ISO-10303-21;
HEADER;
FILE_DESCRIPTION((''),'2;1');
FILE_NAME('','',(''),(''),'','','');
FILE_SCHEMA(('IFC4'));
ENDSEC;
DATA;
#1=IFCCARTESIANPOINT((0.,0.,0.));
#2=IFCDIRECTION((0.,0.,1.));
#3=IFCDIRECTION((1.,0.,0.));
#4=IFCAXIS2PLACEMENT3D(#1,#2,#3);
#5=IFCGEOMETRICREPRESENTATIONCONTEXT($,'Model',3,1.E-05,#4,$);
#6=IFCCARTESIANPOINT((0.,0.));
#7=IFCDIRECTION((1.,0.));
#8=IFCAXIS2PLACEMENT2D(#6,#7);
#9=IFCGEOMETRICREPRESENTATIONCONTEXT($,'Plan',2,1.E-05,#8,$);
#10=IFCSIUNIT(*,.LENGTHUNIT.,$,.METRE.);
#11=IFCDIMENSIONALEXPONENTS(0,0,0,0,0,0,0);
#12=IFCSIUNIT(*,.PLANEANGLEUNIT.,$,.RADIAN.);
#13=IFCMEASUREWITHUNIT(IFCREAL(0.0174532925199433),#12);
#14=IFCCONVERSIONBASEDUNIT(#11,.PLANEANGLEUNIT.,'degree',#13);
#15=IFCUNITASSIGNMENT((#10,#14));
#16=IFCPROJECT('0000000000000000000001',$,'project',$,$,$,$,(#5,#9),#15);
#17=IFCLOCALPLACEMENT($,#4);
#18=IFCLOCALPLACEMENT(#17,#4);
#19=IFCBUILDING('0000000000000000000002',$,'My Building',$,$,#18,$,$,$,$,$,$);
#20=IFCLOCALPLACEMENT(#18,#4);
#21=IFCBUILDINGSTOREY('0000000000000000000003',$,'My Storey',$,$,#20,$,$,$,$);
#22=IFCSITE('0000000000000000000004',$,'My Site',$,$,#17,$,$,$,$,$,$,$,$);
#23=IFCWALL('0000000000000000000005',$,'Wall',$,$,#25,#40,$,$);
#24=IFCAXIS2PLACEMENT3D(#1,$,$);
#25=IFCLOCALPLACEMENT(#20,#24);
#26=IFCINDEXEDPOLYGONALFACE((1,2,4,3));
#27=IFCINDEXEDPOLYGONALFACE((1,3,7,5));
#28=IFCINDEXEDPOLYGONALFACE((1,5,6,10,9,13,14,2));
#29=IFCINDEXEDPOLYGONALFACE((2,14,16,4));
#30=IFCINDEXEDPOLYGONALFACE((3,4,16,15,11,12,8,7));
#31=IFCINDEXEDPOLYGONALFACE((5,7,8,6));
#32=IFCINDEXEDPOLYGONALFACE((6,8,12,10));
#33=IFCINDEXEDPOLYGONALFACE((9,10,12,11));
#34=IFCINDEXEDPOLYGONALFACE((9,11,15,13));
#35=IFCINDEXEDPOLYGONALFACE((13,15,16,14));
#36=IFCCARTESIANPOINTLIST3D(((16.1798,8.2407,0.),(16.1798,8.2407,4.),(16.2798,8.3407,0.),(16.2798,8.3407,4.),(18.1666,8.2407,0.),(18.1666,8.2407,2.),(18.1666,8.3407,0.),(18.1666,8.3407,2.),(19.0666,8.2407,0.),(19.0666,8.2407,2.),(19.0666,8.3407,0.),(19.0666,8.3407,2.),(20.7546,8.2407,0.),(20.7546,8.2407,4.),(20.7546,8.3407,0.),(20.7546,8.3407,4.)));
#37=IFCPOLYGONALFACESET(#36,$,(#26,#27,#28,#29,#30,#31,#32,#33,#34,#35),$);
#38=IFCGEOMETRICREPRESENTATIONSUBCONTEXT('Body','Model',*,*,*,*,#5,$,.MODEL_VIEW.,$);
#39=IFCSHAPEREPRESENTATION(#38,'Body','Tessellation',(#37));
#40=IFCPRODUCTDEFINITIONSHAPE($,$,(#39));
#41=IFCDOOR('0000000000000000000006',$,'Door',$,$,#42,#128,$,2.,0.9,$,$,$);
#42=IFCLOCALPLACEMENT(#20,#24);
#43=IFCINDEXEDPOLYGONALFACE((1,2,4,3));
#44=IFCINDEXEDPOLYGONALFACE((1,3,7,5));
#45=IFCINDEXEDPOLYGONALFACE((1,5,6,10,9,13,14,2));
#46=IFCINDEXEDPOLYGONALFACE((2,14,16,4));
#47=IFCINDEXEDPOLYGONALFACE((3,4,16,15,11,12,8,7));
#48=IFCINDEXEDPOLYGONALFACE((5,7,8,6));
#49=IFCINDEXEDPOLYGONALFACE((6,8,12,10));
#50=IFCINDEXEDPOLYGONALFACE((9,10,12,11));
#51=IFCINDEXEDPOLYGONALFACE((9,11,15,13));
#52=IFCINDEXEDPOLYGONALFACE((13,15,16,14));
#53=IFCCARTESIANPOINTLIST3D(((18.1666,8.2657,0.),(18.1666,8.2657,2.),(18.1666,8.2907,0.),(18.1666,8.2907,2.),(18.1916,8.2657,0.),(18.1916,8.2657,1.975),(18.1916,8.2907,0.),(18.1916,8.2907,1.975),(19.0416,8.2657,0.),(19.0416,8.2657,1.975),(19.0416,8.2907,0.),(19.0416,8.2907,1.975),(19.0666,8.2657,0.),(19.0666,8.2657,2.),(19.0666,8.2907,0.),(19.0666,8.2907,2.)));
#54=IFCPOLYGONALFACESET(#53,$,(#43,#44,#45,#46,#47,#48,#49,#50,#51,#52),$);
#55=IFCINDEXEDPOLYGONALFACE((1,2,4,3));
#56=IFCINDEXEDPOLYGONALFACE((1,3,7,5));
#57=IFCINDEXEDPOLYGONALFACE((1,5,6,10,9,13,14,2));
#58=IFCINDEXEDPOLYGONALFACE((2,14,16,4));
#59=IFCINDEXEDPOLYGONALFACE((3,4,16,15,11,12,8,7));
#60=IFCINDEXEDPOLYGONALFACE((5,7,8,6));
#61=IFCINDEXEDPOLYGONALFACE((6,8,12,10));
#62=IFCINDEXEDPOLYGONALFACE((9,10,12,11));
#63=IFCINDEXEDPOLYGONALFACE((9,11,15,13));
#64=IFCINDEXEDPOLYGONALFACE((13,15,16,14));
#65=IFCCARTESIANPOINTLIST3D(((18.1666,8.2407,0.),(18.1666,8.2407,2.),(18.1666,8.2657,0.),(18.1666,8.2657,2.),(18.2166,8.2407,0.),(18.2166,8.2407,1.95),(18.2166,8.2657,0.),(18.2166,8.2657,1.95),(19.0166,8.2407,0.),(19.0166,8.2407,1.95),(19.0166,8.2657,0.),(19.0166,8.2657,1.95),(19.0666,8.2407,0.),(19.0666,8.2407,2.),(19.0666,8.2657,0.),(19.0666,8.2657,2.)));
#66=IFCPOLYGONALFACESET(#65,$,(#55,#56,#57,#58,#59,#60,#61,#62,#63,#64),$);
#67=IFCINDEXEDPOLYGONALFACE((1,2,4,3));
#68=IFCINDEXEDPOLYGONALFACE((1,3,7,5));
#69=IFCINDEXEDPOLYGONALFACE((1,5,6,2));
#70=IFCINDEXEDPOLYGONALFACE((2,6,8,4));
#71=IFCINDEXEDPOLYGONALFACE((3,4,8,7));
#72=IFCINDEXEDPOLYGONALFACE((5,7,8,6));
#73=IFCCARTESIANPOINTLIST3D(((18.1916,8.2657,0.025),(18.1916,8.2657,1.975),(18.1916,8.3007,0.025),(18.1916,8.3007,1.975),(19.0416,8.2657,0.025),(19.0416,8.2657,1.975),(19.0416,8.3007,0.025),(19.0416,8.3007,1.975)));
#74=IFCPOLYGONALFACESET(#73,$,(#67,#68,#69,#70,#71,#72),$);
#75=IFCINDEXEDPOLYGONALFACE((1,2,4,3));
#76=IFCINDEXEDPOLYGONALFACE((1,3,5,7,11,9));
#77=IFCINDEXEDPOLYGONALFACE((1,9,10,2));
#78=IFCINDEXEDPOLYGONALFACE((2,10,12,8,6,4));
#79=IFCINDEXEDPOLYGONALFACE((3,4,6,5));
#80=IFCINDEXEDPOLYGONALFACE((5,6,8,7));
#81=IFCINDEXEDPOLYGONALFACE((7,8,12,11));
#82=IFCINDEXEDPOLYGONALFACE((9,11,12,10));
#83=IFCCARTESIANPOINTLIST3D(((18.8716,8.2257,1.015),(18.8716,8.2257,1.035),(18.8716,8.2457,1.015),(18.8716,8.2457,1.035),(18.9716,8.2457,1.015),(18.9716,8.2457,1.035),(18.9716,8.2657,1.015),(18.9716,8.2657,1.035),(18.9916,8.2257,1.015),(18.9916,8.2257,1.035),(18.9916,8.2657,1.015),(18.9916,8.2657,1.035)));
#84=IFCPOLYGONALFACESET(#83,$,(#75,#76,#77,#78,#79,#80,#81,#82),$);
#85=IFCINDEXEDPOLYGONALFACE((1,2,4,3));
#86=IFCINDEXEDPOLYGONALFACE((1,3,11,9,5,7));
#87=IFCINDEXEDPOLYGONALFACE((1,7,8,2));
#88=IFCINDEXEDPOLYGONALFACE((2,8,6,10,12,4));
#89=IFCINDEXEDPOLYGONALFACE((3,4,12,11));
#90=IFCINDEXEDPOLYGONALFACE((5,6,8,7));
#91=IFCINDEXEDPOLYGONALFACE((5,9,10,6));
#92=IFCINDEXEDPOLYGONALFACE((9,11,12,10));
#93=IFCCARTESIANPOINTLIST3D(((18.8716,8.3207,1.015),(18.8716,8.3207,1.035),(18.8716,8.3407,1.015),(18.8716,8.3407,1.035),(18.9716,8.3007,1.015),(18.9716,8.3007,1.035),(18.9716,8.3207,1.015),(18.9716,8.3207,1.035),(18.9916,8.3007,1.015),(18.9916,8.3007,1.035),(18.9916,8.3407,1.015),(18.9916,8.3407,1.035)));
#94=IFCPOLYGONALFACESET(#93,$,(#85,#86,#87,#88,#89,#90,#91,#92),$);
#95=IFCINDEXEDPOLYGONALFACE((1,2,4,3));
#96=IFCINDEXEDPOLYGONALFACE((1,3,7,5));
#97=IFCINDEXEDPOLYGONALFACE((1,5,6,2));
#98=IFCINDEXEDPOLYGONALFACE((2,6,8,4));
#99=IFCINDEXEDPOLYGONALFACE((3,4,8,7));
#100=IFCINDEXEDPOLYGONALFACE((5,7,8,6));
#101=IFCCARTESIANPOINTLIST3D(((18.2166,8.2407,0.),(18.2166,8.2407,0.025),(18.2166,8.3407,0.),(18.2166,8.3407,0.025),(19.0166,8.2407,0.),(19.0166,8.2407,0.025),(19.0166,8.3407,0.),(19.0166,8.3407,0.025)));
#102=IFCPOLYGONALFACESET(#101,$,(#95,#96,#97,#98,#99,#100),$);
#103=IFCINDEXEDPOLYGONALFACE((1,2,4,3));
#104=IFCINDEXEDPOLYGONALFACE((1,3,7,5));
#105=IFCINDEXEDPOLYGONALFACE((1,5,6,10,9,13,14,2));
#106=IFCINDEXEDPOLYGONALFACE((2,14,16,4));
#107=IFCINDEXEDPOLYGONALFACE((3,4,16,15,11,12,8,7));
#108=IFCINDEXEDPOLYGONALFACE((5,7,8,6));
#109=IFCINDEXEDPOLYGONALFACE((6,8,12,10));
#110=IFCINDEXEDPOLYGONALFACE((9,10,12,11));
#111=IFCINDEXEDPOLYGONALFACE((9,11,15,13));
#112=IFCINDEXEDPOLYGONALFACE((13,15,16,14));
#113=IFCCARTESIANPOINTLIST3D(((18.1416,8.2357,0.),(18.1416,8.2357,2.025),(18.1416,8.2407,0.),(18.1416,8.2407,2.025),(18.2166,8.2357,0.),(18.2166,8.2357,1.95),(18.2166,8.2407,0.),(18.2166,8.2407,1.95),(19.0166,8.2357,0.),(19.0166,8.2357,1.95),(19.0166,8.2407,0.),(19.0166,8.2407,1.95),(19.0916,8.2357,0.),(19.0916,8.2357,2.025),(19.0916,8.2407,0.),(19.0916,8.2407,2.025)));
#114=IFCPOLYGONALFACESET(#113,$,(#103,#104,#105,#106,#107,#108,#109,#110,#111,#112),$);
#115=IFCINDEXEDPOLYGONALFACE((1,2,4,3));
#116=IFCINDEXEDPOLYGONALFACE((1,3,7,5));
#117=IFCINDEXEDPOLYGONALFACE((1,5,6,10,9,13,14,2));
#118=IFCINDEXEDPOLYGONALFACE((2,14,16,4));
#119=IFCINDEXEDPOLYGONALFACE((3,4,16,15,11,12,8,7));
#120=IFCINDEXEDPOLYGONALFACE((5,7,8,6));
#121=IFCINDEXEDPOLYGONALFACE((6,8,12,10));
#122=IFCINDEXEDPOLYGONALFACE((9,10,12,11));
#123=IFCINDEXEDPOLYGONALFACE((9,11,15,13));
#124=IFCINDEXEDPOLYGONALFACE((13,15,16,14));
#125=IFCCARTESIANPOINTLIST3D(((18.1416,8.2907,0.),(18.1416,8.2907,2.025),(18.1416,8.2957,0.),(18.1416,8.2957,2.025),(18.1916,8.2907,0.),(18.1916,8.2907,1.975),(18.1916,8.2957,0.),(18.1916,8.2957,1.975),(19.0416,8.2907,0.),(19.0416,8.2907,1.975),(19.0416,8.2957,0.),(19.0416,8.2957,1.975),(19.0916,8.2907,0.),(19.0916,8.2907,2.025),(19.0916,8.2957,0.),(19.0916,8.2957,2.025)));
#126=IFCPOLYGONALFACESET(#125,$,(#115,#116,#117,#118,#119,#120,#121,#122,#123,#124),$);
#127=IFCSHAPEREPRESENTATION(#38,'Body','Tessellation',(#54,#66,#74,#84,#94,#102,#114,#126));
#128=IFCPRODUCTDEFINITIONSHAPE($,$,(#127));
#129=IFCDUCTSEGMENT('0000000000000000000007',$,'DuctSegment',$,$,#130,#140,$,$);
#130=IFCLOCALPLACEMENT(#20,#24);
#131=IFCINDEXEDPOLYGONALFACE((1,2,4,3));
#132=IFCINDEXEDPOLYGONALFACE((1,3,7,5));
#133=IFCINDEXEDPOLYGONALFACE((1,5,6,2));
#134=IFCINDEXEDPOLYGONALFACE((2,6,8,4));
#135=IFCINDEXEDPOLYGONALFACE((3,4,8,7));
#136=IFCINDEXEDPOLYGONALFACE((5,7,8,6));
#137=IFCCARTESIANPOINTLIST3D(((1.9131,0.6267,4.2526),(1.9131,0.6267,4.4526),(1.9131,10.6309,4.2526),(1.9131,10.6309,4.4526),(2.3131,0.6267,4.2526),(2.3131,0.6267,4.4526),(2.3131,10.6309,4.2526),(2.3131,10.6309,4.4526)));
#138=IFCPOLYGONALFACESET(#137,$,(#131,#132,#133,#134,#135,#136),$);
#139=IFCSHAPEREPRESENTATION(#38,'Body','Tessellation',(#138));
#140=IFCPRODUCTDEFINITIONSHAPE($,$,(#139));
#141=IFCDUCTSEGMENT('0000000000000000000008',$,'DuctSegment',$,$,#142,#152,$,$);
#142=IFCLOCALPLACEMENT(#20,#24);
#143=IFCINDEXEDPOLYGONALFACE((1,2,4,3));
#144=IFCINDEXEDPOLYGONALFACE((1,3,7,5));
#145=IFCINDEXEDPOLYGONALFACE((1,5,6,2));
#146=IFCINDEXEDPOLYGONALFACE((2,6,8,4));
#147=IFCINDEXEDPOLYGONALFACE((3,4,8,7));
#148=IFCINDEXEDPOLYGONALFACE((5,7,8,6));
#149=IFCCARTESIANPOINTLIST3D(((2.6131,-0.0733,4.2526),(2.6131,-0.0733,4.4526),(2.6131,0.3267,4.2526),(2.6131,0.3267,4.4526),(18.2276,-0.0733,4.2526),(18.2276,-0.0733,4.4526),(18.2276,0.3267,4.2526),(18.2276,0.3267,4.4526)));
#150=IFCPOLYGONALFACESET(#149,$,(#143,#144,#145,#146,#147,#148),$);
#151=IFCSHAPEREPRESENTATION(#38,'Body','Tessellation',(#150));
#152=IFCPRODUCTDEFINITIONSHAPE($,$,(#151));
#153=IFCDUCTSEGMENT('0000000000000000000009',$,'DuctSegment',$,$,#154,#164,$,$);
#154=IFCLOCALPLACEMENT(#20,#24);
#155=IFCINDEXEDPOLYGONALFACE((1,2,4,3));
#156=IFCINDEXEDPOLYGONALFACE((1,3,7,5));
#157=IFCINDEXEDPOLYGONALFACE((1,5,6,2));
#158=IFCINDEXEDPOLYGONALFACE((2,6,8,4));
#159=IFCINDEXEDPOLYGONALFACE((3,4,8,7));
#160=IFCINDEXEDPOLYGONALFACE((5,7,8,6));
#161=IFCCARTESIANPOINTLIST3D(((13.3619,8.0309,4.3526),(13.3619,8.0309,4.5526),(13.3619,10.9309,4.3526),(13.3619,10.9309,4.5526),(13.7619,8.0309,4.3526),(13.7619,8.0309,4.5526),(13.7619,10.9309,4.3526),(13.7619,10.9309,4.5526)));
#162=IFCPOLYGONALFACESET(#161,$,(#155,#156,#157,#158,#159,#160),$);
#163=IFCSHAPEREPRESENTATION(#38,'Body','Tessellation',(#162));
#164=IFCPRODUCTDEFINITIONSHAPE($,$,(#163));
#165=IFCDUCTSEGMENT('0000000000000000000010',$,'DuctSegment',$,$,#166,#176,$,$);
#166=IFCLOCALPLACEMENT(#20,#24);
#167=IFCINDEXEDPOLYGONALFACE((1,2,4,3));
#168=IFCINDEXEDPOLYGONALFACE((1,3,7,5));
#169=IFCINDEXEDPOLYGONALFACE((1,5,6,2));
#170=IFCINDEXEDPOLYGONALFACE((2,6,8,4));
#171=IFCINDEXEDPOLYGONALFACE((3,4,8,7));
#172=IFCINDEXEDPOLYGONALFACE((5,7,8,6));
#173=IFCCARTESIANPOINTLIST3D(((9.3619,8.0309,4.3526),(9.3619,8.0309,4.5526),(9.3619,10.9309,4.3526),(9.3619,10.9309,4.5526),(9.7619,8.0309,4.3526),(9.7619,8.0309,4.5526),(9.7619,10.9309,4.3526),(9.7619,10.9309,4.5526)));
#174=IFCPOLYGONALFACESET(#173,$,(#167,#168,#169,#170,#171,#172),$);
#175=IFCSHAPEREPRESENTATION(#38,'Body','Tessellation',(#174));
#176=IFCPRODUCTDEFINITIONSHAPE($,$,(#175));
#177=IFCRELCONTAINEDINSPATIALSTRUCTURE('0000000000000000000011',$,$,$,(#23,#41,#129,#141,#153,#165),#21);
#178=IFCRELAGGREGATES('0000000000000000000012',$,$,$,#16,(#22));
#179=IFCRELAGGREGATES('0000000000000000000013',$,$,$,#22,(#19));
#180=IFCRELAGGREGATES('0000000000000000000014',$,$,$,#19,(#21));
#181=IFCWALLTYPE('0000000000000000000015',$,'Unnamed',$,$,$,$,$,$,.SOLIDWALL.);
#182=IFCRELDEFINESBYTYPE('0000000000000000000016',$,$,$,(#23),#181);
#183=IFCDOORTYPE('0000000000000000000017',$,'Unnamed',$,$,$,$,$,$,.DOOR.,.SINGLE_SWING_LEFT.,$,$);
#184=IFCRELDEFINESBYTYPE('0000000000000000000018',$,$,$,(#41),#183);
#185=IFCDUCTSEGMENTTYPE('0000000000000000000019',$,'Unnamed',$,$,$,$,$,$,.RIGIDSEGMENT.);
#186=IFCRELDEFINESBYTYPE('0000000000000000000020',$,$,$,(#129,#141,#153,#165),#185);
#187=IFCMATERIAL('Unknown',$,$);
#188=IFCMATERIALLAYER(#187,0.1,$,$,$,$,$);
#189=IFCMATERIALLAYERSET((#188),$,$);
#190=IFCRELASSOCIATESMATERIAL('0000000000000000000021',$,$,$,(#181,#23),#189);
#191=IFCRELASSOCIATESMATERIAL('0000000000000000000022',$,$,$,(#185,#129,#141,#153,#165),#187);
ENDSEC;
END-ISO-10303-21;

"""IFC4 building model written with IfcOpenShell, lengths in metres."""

from ifc_helpers import new_model, entity, si_unit, converted_unit, frame, origin_with_axes, origin_2d_with_axis, place, context, subcontext, project, spatial, line, indexed_curve, rectangle, outline, extrude, shape, source, transform, mapped, material, layer, layer_set, layer_usage, material_profile, profile_set, profile_usage, type_object, type_shapes, element, fill, save


model = new_model("IFC4")

# Units and contexts
model_context = context("Model", 3, precision=1e-05, world=origin_with_axes())
plan_context = context("Plan", 2, precision=1e-05, world=origin_2d_with_axis())
body_context_1 = subcontext(model_context, "Body", "Model", "MODEL_VIEW")
body_context_2 = subcontext(plan_context, "Body", "Plan", "PLAN_VIEW")
ifc_project = project(units=[si_unit("LENGTHUNIT", "METRE"), converted_unit("PLANEANGLEUNIT", "degree", entity("IfcReal", 0.0174532925199433), si_unit("PLANEANGLEUNIT", "RADIAN"), dimensions=[0, 0, 0, 0, 0, 0, 0])], contexts=[model_context, plan_context])

# Site, building, storey
site_placement = place(None, origin_with_axes())
site = spatial("IfcSite", under=ifc_project, at=site_placement, Name="My Site")
building_placement = place(site_placement, origin_with_axes())
building = spatial("IfcBuilding", under=site, at=building_placement, Name="My Building")
storey_placement = place(building_placement, origin_with_axes())
storey = spatial("IfcBuildingStorey", under=building, at=storey_placement, Name="My Storey")

# Shared definitions
ifc_material = material(Name="Unknown")

# Shared definitions
ifc_layer = layer(ifc_material, 0.1)
ifc_layer_set = layer_set([ifc_layer])
wall_type = type_object("IfcWallType", Name="Unnamed", PredefinedType="SOLIDWALL", material=ifc_layer_set)
shared_shape_1 = source(origin_with_axes(), body_context_1, "Body", "SweptSolid", [
    extrude(outline(indexed_curve([(0.0, 0.0), (0.9, 0.0), (0.9, 2.0), (0.0, 2.0)], segments=[line(1, 2, 3, 4, 1)])), frame((0.0, -0.6, 0.0), z_axis=(0.0, -1.0, 0.0), x_axis=(1.0, 0.0, 0.0)), (0.0, 0.0, -1.0), 1.2),
])
door_type = type_object("IfcDoorType", Name="Unnamed", OperationType="SINGLE_SWING_LEFT", PredefinedType="DOOR")
shared_shape_2 = source(origin_with_axes(), body_context_1, "Body", "SweptSolid", [
    extrude(outline(indexed_curve([(0.0, 0.0), (0.0, 2.0), (0.9, 2.0), (0.9, 0.0), (0.875, 0.0), (0.875, 1.975), (0.025, 1.975), (0.025, 0.0)], segments=[line(1, 2, 3, 4, 5, 6, 7, 8, 1)])), frame((0.0, 0.025, 0.0), z_axis=(0.0, -1.0, 0.0), x_axis=(1.0, 0.0, 0.0)), (0.0, 0.0, -1.0), 0.025),
    extrude(outline(indexed_curve([(0.0, 0.0), (0.0, 2.0), (0.9, 2.0), (0.9, 0.0), (0.85, 0.0), (0.85, 1.95), (0.05, 1.95), (0.05, 0.0)], segments=[line(1, 2, 3, 4, 5, 6, 7, 8, 1)])), frame((0.0, 0.0, 0.0), z_axis=(0.0, -1.0, 0.0), x_axis=(1.0, 0.0, 0.0)), (0.0, 0.0, -1.0), 0.025),
    extrude(outline(indexed_curve([(0.0, 0.0), (0.85, 0.0), (0.85, 0.035), (0.0, 0.035)], segments=[line(1, 2, 3, 4, 1)])), frame((0.025, 0.025, 0.025), z_axis=(0.0, 0.0, 1.0), x_axis=(1.0, 0.0, 0.0)), (0.0, 0.0, 1.0), 1.95),
    extrude(outline(indexed_curve([(0.0, 0.0), (0.0, -0.04), (-0.12, -0.04), (-0.12, -0.02), (-0.02, -0.02), (-0.02, 0.0)], segments=[line(1, 2, 3, 4, 5, 6, 1)])), frame((0.825, 0.025, 1.015), z_axis=(0.0, 0.0, 1.0), x_axis=(1.0, 0.0, 0.0)), (0.0, 0.0, 1.0), 0.02),
    extrude(outline(indexed_curve([(0.0, 0.0), (0.0, 0.04), (-0.12, 0.04), (-0.12, 0.02), (-0.02, 0.02), (-0.02, 0.0)], segments=[line(1, 2, 3, 4, 5, 6, 1)])), frame((0.825, 0.06, 1.015), z_axis=(0.0, 0.0, 1.0), x_axis=(1.0, 0.0, 0.0)), (0.0, 0.0, 1.0), 0.02),
    extrude(outline(indexed_curve([(0.0, 0.0), (0.8, 0.0), (0.8, 0.1), (0.0, 0.1)], segments=[line(1, 2, 3, 4, 1)])), frame((0.05, 0.0, 0.0), z_axis=(0.0, 0.0, 1.0), x_axis=(1.0, 0.0, 0.0)), (0.0, 0.0, 1.0), 0.025),
    extrude(outline(indexed_curve([(0.0, 0.0), (0.0, 2.025), (0.95, 2.025), (0.95, 0.0), (0.875, 0.0), (0.875, 1.95), (0.075, 1.95), (0.075, 0.0)], segments=[line(1, 2, 3, 4, 5, 6, 7, 8, 1)])), frame((-0.025, -0.005, 0.0), z_axis=(0.0, -1.0, 0.0), x_axis=(1.0, 0.0, 0.0)), (0.0, 0.0, -1.0), 0.005),
    extrude(outline(indexed_curve([(0.0, 0.0), (0.0, 2.025), (0.95, 2.025), (0.95, 0.0), (0.9, 0.0), (0.9, 1.975), (0.05, 1.975), (0.05, 0.0)], segments=[line(1, 2, 3, 4, 5, 6, 7, 8, 1)])), frame((-0.025, 0.05, 0.0), z_axis=(0.0, -1.0, 0.0), x_axis=(1.0, 0.0, 0.0)), (0.0, 0.0, -1.0), 0.005),
])
shared_shape_3 = source(origin_with_axes(), body_context_2, "Body", "Curve2D", [
    entity("IfcIndexedPolyCurve", entity("IfcCartesianPointList2D", [[0.0, 0.0], [0.0, 0.05], [0.025, 0.05], [0.025, 0.025], [0.05, 0.025], [0.05, 0.0]]), [entity("IfcLineIndex", [1, 2, 3, 4, 5, 6, 1])]),
    entity("IfcIndexedPolyCurve", entity("IfcCartesianPointList2D", [[0.9, 0.0], [0.9, 0.05], [0.875, 0.05], [0.875, 0.025], [0.85, 0.025], [0.85, 0.0]]), [entity("IfcLineIndex", [1, 2, 3, 4, 5, 6, 1])]),
    entity("IfcTrimmedCurve", entity("IfcEllipse", entity("IfcAxis2Placement2D", entity("IfcCartesianPoint", [0.06, 0.05]), entity("IfcDirection", [1.0, 0.0])), 0.815, 0.85), [entity("IfcCartesianPoint", [0.875, 0.05])], [entity("IfcCartesianPoint", [0.06, 0.9])], True, "CARTESIAN"),
    entity("IfcIndexedPolyCurve", entity("IfcCartesianPointList2D", [[0.025, 0.05], [0.06, 0.05], [0.06, 0.9], [0.025, 0.9]]), [entity("IfcLineIndex", [1, 2, 3, 4, 1])]),
])
type_shapes(door_type, [shared_shape_2, shared_shape_3])

# Wall, opening, door
ifc_layer_usage_1 = layer_usage(ifc_layer_set, "AXIS2", "POSITIVE", 0.0)
wall_1_placement = place(storey_placement, frame((16.1798, 8.2407, 0.0), z_axis=(0.0, 0.0, 1.0), x_axis=(1.0, 0.0, 0.0)))
wall_1 = element("IfcWall", 1, at=wall_1_placement, inside=storey, type_object=wall_type, material=ifc_layer_usage_1, Name="Wall", context=body_context_1, shape_type="SweptSolid", body=[
    extrude(outline(indexed_curve([(0.0, 0.0), (0.1, 0.1), (4.5748, 0.1), (4.5748, 0.0)], segments=[line(1, 2, 3, 4, 1)])), origin_with_axes(), (0.0, 0.0, 1.0), 4.0),
])
opening_1_placement = place(wall_1_placement, frame((1.9868, 0.0, 0.0), z_axis=(0.0, 0.0, 1.0), x_axis=(1.0, 0.0, 0.0)))
opening_1 = element("IfcOpeningElement", 2, at=opening_1_placement, cuts=wall_1, PredefinedType="OPENING", context=body_context_1, shape_type="MappedRepresentation", body=[
    mapped(shared_shape_1, transform((0.0, 0.0, 0.0), x_axis=(1.0, 0.0, 0.0), y_axis=(0.0, 1.0, 0.0), z_axis=(0.0, 0.0, 1.0), scale=1.0)),
])
door_1_placement = place(opening_1_placement, origin_with_axes())
door_1 = element("IfcDoor", 3, at=door_1_placement, inside=storey, type_object=door_type, Name="Door", OverallHeight=2.0, OverallWidth=0.9, shapes=[
    shape(body_context_1, "Body", "MappedRepresentation", [mapped(shared_shape_2, transform((0.0, 0.0, 0.0), x_axis=(1.0, 0.0, 0.0), y_axis=(0.0, 1.0, 0.0), z_axis=(0.0, 0.0, 1.0), scale=1.0))]),
    shape(body_context_2, "Body", "MappedRepresentation", [mapped(shared_shape_3, transform((0.0, 0.0, 0.0), x_axis=(1.0, 0.0, 0.0), y_axis=(0.0, 1.0, 0.0), z_axis=(0.0, 0.0, 1.0), scale=1.0))]),
])
fill(opening_1, door_1)

# Duct segments
ifc_material_profile_1 = material_profile(ifc_material, rectangle(XDim=0.4, YDim=0.2))
ifc_profile_set_1 = profile_set([ifc_material_profile_1])
ifc_profile_usage_1 = profile_usage(ifc_profile_set_1, cardinal=5)
duct_segment_type = type_object("IfcDuctSegmentType", Name="Unnamed", PredefinedType="RIGIDSEGMENT", material=ifc_profile_set_1)
duct_segment_1_placement = place(storey_placement, frame((2.1131, 10.6309, 4.3526), z_axis=(0.0, -1.0, 0.0), x_axis=(1.0, 0.0, 0.0)))
element("IfcDuctSegment", 4, at=duct_segment_1_placement, inside=storey, type_object=duct_segment_type, material=ifc_profile_usage_1, Name="DuctSegment", context=body_context_1, shape_type="SweptSolid", body=[
    extrude(rectangle(XDim=0.4, YDim=0.2), origin_with_axes(), (0.0, 0.0, 1.0), 10.0042),
])
ifc_profile_usage_2 = profile_usage(ifc_profile_set_1, cardinal=5)
duct_segment_2_placement = place(storey_placement, frame((18.2276, 0.1267, 4.3526), z_axis=(-1.0, 0.0, 0.0), x_axis=(0.0, -1.0, 0.0)))
element("IfcDuctSegment", 5, at=duct_segment_2_placement, inside=storey, type_object=duct_segment_type, material=ifc_profile_usage_2, Name="DuctSegment", context=body_context_1, shape_type="SweptSolid", body=[
    extrude(rectangle(XDim=0.4, YDim=0.2), origin_with_axes(), (0.0, 0.0, 1.0), 15.6145),
])
ifc_profile_usage_3 = profile_usage(ifc_profile_set_1, cardinal=5)
duct_segment_3_placement = place(storey_placement, frame((13.5619, 10.9309, 4.4526), z_axis=(0.0, -1.0, 0.0), x_axis=(1.0, 0.0, 0.0)))
element("IfcDuctSegment", 6, at=duct_segment_3_placement, inside=storey, type_object=duct_segment_type, material=ifc_profile_usage_3, Name="DuctSegment", context=body_context_1, shape_type="SweptSolid", body=[
    extrude(rectangle(XDim=0.4, YDim=0.2), origin_with_axes(), (0.0, 0.0, 1.0), 2.9),
])
ifc_profile_usage_4 = profile_usage(ifc_profile_set_1, cardinal=5)
duct_segment_4_placement = place(storey_placement, frame((9.5619, 10.9309, 4.4526), z_axis=(0.0, -1.0, 0.0), x_axis=(1.0, 0.0, 0.0)))
element("IfcDuctSegment", 7, at=duct_segment_4_placement, inside=storey, type_object=duct_segment_type, material=ifc_profile_usage_4, Name="DuctSegment", context=body_context_1, shape_type="SweptSolid", body=[
    extrude(rectangle(XDim=0.4, YDim=0.2), origin_with_axes(), (0.0, 0.0, 1.0), 2.9),
])

save(model, "model.ifc")
